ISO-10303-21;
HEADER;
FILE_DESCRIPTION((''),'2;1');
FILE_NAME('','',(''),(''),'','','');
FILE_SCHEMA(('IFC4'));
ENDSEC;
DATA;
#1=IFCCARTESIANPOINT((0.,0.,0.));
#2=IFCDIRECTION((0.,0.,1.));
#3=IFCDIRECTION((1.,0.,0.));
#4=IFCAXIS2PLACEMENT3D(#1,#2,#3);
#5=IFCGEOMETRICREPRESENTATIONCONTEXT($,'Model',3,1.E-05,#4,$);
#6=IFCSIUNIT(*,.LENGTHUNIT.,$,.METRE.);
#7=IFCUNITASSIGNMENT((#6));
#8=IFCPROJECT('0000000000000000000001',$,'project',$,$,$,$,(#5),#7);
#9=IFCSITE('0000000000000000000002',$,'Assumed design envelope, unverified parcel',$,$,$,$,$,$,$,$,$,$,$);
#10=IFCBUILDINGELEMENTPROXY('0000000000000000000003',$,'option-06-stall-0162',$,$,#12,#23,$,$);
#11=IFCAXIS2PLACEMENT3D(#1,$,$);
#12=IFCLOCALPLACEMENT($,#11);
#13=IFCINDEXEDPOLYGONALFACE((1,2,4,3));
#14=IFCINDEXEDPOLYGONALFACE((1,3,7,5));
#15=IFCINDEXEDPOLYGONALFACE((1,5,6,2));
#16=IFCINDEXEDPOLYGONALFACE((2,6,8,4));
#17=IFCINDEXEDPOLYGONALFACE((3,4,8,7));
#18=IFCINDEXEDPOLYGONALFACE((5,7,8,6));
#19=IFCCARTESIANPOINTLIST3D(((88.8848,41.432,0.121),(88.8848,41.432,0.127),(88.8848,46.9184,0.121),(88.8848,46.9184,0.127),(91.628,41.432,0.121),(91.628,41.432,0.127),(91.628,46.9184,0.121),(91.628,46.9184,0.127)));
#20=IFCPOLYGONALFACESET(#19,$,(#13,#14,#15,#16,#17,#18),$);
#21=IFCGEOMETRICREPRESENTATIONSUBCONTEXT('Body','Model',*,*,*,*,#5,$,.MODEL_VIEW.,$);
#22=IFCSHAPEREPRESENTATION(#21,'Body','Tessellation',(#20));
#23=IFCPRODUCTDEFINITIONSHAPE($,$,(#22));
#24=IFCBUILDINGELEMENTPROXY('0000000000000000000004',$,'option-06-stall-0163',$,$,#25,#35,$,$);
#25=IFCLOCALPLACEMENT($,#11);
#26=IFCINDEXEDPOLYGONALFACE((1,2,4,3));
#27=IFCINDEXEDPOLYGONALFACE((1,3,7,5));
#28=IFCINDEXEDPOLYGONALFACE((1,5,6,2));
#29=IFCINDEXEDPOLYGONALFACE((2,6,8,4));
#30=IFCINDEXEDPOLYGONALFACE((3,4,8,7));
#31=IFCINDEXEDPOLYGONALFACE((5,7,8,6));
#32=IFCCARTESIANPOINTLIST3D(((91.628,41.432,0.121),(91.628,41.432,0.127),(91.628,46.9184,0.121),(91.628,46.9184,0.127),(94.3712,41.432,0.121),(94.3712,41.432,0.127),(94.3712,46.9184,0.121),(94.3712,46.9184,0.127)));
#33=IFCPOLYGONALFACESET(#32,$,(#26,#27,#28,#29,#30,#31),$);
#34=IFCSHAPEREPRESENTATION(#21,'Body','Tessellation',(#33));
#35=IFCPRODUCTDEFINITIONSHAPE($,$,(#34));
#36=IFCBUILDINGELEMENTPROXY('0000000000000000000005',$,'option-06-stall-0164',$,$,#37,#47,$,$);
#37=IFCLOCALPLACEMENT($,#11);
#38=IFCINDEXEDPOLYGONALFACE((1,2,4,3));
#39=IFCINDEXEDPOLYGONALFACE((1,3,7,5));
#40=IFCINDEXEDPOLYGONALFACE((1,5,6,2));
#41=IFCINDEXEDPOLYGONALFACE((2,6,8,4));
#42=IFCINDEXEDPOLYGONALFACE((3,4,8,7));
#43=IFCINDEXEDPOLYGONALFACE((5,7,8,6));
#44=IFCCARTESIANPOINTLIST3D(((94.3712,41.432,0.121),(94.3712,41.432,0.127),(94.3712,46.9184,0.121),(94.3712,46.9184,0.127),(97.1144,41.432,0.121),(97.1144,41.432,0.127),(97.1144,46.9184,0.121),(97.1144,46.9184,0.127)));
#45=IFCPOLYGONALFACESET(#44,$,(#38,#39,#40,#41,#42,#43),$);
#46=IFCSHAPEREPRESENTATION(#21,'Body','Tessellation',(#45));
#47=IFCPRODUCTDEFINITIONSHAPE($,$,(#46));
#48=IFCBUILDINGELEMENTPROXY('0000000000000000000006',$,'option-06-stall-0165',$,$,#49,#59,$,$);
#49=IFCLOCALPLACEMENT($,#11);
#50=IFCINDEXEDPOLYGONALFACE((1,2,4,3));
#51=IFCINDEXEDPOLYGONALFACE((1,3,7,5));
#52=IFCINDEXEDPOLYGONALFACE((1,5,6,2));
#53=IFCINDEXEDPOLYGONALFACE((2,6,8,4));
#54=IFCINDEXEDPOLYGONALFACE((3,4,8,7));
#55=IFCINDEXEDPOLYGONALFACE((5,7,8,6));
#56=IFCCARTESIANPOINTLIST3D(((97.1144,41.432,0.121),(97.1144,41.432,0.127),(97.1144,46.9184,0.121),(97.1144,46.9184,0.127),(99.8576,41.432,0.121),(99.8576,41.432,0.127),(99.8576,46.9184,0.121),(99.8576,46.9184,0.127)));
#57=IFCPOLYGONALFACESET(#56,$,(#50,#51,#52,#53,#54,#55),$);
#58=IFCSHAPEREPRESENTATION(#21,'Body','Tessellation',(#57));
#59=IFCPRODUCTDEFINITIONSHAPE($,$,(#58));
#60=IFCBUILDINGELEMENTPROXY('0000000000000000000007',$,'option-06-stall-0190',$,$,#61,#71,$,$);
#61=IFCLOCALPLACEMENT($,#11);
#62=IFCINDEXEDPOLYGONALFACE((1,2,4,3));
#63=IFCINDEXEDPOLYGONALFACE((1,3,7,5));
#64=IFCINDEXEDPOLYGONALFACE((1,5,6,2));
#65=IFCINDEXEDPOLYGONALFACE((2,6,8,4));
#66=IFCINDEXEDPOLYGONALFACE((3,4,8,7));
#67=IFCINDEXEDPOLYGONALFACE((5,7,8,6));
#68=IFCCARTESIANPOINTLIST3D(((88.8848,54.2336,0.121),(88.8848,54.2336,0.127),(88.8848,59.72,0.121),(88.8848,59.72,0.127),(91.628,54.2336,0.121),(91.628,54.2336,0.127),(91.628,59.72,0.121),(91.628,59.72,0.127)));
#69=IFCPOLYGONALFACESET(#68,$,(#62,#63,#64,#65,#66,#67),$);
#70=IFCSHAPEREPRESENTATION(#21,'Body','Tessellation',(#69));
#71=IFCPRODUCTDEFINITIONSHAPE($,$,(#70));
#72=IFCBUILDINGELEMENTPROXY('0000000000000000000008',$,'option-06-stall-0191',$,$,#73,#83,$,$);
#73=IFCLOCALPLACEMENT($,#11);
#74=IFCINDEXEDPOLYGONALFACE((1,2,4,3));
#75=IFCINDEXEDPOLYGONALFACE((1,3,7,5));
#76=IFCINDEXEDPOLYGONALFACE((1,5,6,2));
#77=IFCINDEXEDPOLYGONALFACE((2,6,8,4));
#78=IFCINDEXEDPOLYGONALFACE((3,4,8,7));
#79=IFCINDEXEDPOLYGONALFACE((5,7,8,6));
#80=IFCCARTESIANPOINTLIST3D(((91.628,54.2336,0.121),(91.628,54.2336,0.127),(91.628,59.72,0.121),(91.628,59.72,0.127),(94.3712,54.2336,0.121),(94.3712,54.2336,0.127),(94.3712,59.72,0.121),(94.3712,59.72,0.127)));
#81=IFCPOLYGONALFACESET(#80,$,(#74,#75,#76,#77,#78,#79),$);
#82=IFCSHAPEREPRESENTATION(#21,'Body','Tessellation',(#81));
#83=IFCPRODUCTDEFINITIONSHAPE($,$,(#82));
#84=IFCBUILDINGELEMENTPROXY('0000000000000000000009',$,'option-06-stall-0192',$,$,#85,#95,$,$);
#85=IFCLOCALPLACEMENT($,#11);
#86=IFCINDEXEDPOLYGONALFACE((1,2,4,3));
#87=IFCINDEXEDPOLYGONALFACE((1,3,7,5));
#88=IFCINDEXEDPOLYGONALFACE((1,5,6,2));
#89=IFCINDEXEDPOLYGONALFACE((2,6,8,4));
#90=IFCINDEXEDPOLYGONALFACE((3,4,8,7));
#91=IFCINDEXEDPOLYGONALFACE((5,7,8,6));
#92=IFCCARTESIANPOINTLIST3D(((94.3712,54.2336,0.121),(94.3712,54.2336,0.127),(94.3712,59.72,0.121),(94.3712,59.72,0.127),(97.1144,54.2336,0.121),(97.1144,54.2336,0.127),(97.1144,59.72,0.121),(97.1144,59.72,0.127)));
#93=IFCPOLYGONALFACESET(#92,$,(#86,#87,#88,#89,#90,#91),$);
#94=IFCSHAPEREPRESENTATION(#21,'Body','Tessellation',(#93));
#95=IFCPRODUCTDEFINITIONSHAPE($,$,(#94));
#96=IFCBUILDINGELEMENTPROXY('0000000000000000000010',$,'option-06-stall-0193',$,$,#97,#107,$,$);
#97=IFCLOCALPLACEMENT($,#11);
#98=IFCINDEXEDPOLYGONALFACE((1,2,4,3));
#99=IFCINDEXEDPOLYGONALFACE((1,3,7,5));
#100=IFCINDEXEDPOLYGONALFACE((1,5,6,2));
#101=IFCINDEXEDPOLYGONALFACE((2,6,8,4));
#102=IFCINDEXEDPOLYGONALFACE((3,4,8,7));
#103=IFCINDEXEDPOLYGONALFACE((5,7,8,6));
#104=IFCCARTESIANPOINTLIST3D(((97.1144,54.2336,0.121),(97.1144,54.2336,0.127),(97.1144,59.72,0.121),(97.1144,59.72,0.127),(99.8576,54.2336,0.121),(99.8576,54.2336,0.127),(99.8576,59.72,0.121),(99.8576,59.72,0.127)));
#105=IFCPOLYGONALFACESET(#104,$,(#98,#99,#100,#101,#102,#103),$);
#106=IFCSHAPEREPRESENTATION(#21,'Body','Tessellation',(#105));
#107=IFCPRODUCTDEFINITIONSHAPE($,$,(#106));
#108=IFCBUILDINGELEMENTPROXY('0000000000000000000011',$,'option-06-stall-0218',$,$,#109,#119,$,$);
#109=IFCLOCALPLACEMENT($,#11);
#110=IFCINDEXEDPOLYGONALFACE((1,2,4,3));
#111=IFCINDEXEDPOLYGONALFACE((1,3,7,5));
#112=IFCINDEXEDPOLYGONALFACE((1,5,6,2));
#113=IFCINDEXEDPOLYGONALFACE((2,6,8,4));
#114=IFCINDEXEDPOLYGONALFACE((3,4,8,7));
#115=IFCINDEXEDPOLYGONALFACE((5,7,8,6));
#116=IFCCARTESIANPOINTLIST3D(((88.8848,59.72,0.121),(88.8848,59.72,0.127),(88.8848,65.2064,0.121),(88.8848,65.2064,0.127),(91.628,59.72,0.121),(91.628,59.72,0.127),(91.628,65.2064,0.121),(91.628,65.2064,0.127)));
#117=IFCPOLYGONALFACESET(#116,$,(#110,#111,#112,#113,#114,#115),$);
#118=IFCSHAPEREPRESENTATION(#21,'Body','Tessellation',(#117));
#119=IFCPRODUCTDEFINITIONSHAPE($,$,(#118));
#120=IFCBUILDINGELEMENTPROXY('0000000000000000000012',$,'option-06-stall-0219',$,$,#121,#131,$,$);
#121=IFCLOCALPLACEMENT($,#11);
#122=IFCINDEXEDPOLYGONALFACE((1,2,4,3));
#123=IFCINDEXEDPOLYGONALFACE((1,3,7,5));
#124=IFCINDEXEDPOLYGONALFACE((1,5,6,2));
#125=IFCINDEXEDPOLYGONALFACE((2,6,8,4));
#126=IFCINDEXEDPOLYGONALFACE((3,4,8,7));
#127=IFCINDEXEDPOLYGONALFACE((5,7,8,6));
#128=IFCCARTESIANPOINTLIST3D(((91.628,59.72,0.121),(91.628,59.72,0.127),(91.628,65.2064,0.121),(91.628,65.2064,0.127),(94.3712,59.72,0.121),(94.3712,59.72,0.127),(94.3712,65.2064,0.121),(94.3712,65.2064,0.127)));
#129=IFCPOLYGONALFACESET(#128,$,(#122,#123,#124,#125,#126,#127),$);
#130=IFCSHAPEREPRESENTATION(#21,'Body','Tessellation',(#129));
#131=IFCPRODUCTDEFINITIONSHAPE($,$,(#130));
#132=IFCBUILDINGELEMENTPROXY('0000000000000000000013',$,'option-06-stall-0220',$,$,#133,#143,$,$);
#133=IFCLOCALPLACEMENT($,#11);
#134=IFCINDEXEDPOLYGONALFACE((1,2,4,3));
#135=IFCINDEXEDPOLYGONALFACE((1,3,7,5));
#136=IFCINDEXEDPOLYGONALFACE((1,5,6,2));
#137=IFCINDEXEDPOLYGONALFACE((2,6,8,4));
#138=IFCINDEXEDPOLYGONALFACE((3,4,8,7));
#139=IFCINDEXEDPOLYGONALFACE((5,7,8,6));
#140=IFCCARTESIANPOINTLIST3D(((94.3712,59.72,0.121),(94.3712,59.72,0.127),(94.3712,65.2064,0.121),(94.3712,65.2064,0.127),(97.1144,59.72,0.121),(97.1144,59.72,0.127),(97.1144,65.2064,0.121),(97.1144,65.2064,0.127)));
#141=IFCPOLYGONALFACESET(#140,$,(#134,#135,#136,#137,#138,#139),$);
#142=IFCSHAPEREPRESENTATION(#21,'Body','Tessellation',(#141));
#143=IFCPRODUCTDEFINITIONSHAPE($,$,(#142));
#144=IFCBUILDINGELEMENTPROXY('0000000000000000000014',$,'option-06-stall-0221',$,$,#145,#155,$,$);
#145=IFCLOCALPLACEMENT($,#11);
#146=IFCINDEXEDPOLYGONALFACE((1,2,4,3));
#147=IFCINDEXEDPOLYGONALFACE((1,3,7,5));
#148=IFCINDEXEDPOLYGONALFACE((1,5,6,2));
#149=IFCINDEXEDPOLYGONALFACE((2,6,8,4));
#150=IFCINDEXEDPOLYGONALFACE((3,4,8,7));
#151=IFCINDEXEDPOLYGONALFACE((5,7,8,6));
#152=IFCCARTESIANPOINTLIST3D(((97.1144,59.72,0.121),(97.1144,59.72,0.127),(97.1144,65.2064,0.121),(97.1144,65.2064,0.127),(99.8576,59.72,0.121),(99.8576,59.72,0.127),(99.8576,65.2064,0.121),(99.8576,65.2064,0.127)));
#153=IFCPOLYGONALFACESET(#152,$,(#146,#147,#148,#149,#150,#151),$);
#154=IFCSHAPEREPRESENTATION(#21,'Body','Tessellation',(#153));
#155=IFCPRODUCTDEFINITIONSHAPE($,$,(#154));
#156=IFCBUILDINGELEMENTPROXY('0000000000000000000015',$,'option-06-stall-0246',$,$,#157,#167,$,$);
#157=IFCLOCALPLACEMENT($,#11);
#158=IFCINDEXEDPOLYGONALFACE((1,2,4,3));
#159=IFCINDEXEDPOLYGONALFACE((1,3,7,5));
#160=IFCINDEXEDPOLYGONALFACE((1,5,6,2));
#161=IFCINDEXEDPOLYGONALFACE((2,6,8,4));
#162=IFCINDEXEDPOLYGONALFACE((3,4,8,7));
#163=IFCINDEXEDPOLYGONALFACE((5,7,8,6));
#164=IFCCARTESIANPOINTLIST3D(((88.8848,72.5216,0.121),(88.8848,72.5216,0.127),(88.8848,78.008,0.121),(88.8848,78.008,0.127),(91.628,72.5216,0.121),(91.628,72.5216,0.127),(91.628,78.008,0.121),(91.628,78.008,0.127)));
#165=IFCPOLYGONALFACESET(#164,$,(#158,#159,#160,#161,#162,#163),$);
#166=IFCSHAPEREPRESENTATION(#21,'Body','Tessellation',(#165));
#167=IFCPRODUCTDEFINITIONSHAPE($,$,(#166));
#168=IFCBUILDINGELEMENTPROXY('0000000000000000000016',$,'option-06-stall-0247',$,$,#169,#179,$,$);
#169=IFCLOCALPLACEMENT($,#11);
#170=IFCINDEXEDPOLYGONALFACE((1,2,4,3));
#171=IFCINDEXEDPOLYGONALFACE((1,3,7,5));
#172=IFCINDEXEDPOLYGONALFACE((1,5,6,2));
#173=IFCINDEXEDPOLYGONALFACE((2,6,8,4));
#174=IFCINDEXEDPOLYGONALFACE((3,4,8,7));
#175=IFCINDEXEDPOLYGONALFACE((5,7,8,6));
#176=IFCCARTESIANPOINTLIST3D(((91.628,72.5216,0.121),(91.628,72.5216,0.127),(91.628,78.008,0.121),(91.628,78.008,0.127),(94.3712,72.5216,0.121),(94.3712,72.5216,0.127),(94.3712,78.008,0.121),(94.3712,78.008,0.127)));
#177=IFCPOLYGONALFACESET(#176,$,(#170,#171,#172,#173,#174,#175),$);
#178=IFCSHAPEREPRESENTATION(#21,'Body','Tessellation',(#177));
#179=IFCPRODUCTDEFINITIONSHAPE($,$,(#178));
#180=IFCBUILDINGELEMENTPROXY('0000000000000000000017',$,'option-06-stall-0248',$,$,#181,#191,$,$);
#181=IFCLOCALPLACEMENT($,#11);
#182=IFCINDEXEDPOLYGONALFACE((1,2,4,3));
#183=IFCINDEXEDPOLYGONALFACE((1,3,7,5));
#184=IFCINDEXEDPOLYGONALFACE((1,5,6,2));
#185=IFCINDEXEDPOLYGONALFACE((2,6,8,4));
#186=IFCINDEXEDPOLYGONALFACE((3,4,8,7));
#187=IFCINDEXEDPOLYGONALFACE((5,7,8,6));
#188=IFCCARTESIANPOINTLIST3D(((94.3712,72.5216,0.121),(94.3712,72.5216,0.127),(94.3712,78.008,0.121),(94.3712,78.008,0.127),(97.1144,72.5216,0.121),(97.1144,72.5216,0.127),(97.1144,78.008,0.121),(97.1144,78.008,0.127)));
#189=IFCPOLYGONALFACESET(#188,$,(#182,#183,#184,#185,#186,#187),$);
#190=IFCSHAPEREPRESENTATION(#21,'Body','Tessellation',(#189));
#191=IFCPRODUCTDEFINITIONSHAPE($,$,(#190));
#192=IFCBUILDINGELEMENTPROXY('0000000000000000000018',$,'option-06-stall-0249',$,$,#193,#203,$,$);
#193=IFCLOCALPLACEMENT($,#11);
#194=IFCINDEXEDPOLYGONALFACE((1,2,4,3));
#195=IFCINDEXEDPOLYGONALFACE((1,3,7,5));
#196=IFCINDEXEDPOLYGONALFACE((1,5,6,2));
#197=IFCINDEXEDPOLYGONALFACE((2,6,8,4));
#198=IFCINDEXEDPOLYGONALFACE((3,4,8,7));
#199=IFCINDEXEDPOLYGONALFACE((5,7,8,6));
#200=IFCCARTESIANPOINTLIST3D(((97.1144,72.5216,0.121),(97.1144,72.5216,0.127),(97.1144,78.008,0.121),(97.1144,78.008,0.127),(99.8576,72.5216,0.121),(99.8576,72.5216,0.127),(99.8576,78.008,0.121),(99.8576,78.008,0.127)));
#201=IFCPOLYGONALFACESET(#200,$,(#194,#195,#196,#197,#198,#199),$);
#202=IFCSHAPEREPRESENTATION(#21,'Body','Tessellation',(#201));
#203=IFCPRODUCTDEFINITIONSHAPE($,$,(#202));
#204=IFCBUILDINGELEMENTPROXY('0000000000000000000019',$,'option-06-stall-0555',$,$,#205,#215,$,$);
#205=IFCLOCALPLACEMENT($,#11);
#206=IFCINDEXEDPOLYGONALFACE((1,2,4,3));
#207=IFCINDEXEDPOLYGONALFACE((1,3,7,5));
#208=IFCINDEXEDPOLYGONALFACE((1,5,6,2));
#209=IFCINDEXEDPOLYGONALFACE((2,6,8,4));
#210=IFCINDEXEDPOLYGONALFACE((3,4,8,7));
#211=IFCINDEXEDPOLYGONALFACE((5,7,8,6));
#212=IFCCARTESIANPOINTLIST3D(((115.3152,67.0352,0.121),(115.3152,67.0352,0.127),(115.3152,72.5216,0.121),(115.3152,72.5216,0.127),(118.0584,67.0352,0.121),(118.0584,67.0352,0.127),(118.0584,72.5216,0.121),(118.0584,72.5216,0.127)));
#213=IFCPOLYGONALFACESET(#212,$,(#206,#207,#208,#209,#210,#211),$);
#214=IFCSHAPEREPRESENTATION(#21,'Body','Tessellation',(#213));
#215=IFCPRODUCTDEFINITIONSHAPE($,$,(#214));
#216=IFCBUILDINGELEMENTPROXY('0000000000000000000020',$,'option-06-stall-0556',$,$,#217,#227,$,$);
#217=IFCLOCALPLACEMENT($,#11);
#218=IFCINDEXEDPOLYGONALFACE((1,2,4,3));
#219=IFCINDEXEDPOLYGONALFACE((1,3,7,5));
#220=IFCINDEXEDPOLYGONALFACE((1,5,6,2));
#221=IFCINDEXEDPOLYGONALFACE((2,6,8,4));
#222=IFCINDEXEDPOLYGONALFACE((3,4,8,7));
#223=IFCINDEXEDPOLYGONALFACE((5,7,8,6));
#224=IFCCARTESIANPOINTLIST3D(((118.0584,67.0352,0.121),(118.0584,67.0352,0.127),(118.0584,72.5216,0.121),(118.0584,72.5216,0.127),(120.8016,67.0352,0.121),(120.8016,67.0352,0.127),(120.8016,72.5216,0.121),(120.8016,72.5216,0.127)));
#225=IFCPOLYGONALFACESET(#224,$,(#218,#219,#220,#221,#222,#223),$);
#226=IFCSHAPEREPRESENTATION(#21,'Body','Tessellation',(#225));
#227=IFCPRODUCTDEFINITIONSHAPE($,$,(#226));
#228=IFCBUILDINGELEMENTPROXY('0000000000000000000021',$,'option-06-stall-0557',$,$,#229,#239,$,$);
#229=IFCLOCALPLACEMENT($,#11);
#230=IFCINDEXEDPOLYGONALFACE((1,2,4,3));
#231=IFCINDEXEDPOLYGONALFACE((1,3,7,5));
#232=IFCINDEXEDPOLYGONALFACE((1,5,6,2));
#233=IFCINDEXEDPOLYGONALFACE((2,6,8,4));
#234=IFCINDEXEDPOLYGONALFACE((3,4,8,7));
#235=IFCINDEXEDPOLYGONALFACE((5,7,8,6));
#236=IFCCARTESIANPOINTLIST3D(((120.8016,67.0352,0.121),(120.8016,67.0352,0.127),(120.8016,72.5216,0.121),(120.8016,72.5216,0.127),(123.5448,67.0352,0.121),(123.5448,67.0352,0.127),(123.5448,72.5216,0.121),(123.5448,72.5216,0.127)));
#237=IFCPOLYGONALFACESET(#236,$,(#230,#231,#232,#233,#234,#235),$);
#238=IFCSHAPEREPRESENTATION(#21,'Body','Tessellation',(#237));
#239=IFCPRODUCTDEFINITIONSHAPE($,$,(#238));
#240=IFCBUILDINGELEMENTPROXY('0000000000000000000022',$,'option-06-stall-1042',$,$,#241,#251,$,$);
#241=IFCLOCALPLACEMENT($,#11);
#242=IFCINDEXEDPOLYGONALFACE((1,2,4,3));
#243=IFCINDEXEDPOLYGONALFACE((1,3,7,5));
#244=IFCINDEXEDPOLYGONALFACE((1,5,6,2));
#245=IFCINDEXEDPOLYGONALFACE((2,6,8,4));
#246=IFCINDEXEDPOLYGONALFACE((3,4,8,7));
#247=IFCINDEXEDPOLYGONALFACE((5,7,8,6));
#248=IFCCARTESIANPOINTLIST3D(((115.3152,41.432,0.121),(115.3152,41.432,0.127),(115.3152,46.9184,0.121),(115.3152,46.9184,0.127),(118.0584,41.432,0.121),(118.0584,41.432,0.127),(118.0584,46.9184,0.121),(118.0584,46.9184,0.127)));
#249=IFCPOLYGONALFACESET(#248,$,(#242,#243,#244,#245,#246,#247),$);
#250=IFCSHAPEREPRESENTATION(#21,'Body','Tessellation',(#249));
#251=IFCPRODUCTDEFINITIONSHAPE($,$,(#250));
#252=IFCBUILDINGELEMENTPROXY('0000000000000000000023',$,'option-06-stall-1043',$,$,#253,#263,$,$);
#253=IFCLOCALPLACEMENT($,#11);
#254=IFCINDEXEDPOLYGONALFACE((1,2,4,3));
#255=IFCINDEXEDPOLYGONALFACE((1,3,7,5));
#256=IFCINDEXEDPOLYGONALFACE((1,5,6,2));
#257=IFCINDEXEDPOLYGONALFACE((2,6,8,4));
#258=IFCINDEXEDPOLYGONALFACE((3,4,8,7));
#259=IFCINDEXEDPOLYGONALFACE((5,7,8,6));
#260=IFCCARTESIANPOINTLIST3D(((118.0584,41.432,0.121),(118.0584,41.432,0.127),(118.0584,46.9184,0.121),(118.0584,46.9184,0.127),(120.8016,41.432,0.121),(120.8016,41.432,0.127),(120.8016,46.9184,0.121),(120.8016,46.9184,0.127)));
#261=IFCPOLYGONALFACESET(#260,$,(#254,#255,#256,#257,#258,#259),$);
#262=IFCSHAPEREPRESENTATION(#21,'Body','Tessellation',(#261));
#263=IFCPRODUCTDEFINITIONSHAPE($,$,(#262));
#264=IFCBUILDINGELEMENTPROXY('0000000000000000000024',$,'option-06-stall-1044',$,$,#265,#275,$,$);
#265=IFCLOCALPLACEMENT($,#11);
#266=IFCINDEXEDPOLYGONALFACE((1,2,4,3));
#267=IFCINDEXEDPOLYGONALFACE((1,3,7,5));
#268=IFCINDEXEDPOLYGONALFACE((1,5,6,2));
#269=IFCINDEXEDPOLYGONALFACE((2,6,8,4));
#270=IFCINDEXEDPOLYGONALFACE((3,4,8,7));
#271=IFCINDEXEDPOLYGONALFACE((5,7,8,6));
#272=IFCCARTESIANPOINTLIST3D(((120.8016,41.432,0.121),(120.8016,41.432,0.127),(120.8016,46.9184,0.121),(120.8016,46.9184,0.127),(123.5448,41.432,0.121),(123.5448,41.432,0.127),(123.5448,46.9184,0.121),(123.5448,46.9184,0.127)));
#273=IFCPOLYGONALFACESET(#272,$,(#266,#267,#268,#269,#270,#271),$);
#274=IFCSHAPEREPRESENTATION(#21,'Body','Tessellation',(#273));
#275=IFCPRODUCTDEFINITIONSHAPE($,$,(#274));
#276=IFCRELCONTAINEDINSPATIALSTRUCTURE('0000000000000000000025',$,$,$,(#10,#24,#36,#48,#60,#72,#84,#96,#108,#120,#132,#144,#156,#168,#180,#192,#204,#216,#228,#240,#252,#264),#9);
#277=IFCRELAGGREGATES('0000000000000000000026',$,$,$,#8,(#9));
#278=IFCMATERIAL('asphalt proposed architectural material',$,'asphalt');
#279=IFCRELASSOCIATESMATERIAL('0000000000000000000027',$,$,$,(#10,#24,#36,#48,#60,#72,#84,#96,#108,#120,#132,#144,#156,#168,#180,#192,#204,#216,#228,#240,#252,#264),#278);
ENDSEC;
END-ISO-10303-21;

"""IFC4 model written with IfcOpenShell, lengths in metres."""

from ifc_helpers import new_model, si_unit, frame, origin_with_axes, place, context, subcontext, project, spatial, rectangle, extrude, material, element, save


model = new_model("IFC4")

# Units and contexts
model_context = context("Model", 3, precision=1e-05, world=origin_with_axes())
body_context = subcontext(model_context, "Body", "Model", "MODEL_VIEW")
ifc_project = project(units=[si_unit("LENGTHUNIT", "METRE")], contexts=[model_context])

# Site
site = spatial("IfcSite", under=ifc_project, Name="Assumed design envelope, unverified parcel")

# Building element proxies
ifc_material = material(Name="asphalt proposed architectural material", Category="asphalt")
for number, where, z_axis, x_axis, name in (
    (1, (90.2564, 44.1752, 0.121), (0.0, 0.0, 1.0), (1.0, 0.0, 0.0), "option-06-stall-0162"),
    (2, (92.9996, 44.1752, 0.121), (0.0, 0.0, 1.0), (1.0, 0.0, 0.0), "option-06-stall-0163"),
    (3, (95.7428, 44.1752, 0.121), (0.0, 0.0, 1.0), (1.0, 0.0, 0.0), "option-06-stall-0164"),
    (4, (98.486, 44.1752, 0.121), (0.0, 0.0, 1.0), (1.0, 0.0, 0.0), "option-06-stall-0165"),
    (5, (90.2564, 56.9768, 0.121), (0.0, 0.0, 1.0), (1.0, 0.0, 0.0), "option-06-stall-0190"),
    (6, (92.9996, 56.9768, 0.121), (0.0, 0.0, 1.0), (1.0, 0.0, 0.0), "option-06-stall-0191"),
    (7, (95.7428, 56.9768, 0.121), (0.0, 0.0, 1.0), (1.0, 0.0, 0.0), "option-06-stall-0192"),
    (8, (98.486, 56.9768, 0.121), (0.0, 0.0, 1.0), (1.0, 0.0, 0.0), "option-06-stall-0193"),
    (9, (90.2564, 62.4632, 0.121), (0.0, 0.0, 1.0), (1.0, 0.0, 0.0), "option-06-stall-0218"),
    (10, (92.9996, 62.4632, 0.121), (0.0, 0.0, 1.0), (1.0, 0.0, 0.0), "option-06-stall-0219"),
    (11, (95.7428, 62.4632, 0.121), (0.0, 0.0, 1.0), (1.0, 0.0, 0.0), "option-06-stall-0220"),
    (12, (98.486, 62.4632, 0.121), (0.0, 0.0, 1.0), (1.0, 0.0, 0.0), "option-06-stall-0221"),
    (13, (90.2564, 75.2648, 0.121), (0.0, 0.0, 1.0), (1.0, 0.0, 0.0), "option-06-stall-0246"),
    (14, (92.9996, 75.2648, 0.121), (0.0, 0.0, 1.0), (1.0, 0.0, 0.0), "option-06-stall-0247"),
    (15, (95.7428, 75.2648, 0.121), (0.0, 0.0, 1.0), (1.0, 0.0, 0.0), "option-06-stall-0248"),
    (16, (98.486, 75.2648, 0.121), (0.0, 0.0, 1.0), (1.0, 0.0, 0.0), "option-06-stall-0249"),
    (17, (116.6868, 69.7784, 0.121), (0.0, 0.0, 1.0), (1.0, 0.0, 0.0), "option-06-stall-0555"),
    (18, (119.43, 69.7784, 0.121), (0.0, 0.0, 1.0), (1.0, 0.0, 0.0), "option-06-stall-0556"),
    (19, (122.1732, 69.7784, 0.121), (0.0, 0.0, 1.0), (1.0, 0.0, 0.0), "option-06-stall-0557"),
    (20, (116.6868, 44.1752, 0.121), (0.0, 0.0, 1.0), (1.0, 0.0, 0.0), "option-06-stall-1042"),
    (21, (119.43, 44.1752, 0.121), (0.0, 0.0, 1.0), (1.0, 0.0, 0.0), "option-06-stall-1043"),
    (22, (122.1732, 44.1752, 0.121), (0.0, 0.0, 1.0), (1.0, 0.0, 0.0), "option-06-stall-1044"),
):
    element("IfcBuildingElementProxy", number, at=place(None, frame(where, z_axis=z_axis, x_axis=x_axis)), inside=site, material=ifc_material, Name=name, context=body_context, shape_type="SweptSolid", body=[
        extrude(rectangle(XDim=2.7432, YDim=5.4864), origin_with_axes(), (0.0, 0.0, 1.0), 0.006),
    ])

save(model, "model.ifc")
